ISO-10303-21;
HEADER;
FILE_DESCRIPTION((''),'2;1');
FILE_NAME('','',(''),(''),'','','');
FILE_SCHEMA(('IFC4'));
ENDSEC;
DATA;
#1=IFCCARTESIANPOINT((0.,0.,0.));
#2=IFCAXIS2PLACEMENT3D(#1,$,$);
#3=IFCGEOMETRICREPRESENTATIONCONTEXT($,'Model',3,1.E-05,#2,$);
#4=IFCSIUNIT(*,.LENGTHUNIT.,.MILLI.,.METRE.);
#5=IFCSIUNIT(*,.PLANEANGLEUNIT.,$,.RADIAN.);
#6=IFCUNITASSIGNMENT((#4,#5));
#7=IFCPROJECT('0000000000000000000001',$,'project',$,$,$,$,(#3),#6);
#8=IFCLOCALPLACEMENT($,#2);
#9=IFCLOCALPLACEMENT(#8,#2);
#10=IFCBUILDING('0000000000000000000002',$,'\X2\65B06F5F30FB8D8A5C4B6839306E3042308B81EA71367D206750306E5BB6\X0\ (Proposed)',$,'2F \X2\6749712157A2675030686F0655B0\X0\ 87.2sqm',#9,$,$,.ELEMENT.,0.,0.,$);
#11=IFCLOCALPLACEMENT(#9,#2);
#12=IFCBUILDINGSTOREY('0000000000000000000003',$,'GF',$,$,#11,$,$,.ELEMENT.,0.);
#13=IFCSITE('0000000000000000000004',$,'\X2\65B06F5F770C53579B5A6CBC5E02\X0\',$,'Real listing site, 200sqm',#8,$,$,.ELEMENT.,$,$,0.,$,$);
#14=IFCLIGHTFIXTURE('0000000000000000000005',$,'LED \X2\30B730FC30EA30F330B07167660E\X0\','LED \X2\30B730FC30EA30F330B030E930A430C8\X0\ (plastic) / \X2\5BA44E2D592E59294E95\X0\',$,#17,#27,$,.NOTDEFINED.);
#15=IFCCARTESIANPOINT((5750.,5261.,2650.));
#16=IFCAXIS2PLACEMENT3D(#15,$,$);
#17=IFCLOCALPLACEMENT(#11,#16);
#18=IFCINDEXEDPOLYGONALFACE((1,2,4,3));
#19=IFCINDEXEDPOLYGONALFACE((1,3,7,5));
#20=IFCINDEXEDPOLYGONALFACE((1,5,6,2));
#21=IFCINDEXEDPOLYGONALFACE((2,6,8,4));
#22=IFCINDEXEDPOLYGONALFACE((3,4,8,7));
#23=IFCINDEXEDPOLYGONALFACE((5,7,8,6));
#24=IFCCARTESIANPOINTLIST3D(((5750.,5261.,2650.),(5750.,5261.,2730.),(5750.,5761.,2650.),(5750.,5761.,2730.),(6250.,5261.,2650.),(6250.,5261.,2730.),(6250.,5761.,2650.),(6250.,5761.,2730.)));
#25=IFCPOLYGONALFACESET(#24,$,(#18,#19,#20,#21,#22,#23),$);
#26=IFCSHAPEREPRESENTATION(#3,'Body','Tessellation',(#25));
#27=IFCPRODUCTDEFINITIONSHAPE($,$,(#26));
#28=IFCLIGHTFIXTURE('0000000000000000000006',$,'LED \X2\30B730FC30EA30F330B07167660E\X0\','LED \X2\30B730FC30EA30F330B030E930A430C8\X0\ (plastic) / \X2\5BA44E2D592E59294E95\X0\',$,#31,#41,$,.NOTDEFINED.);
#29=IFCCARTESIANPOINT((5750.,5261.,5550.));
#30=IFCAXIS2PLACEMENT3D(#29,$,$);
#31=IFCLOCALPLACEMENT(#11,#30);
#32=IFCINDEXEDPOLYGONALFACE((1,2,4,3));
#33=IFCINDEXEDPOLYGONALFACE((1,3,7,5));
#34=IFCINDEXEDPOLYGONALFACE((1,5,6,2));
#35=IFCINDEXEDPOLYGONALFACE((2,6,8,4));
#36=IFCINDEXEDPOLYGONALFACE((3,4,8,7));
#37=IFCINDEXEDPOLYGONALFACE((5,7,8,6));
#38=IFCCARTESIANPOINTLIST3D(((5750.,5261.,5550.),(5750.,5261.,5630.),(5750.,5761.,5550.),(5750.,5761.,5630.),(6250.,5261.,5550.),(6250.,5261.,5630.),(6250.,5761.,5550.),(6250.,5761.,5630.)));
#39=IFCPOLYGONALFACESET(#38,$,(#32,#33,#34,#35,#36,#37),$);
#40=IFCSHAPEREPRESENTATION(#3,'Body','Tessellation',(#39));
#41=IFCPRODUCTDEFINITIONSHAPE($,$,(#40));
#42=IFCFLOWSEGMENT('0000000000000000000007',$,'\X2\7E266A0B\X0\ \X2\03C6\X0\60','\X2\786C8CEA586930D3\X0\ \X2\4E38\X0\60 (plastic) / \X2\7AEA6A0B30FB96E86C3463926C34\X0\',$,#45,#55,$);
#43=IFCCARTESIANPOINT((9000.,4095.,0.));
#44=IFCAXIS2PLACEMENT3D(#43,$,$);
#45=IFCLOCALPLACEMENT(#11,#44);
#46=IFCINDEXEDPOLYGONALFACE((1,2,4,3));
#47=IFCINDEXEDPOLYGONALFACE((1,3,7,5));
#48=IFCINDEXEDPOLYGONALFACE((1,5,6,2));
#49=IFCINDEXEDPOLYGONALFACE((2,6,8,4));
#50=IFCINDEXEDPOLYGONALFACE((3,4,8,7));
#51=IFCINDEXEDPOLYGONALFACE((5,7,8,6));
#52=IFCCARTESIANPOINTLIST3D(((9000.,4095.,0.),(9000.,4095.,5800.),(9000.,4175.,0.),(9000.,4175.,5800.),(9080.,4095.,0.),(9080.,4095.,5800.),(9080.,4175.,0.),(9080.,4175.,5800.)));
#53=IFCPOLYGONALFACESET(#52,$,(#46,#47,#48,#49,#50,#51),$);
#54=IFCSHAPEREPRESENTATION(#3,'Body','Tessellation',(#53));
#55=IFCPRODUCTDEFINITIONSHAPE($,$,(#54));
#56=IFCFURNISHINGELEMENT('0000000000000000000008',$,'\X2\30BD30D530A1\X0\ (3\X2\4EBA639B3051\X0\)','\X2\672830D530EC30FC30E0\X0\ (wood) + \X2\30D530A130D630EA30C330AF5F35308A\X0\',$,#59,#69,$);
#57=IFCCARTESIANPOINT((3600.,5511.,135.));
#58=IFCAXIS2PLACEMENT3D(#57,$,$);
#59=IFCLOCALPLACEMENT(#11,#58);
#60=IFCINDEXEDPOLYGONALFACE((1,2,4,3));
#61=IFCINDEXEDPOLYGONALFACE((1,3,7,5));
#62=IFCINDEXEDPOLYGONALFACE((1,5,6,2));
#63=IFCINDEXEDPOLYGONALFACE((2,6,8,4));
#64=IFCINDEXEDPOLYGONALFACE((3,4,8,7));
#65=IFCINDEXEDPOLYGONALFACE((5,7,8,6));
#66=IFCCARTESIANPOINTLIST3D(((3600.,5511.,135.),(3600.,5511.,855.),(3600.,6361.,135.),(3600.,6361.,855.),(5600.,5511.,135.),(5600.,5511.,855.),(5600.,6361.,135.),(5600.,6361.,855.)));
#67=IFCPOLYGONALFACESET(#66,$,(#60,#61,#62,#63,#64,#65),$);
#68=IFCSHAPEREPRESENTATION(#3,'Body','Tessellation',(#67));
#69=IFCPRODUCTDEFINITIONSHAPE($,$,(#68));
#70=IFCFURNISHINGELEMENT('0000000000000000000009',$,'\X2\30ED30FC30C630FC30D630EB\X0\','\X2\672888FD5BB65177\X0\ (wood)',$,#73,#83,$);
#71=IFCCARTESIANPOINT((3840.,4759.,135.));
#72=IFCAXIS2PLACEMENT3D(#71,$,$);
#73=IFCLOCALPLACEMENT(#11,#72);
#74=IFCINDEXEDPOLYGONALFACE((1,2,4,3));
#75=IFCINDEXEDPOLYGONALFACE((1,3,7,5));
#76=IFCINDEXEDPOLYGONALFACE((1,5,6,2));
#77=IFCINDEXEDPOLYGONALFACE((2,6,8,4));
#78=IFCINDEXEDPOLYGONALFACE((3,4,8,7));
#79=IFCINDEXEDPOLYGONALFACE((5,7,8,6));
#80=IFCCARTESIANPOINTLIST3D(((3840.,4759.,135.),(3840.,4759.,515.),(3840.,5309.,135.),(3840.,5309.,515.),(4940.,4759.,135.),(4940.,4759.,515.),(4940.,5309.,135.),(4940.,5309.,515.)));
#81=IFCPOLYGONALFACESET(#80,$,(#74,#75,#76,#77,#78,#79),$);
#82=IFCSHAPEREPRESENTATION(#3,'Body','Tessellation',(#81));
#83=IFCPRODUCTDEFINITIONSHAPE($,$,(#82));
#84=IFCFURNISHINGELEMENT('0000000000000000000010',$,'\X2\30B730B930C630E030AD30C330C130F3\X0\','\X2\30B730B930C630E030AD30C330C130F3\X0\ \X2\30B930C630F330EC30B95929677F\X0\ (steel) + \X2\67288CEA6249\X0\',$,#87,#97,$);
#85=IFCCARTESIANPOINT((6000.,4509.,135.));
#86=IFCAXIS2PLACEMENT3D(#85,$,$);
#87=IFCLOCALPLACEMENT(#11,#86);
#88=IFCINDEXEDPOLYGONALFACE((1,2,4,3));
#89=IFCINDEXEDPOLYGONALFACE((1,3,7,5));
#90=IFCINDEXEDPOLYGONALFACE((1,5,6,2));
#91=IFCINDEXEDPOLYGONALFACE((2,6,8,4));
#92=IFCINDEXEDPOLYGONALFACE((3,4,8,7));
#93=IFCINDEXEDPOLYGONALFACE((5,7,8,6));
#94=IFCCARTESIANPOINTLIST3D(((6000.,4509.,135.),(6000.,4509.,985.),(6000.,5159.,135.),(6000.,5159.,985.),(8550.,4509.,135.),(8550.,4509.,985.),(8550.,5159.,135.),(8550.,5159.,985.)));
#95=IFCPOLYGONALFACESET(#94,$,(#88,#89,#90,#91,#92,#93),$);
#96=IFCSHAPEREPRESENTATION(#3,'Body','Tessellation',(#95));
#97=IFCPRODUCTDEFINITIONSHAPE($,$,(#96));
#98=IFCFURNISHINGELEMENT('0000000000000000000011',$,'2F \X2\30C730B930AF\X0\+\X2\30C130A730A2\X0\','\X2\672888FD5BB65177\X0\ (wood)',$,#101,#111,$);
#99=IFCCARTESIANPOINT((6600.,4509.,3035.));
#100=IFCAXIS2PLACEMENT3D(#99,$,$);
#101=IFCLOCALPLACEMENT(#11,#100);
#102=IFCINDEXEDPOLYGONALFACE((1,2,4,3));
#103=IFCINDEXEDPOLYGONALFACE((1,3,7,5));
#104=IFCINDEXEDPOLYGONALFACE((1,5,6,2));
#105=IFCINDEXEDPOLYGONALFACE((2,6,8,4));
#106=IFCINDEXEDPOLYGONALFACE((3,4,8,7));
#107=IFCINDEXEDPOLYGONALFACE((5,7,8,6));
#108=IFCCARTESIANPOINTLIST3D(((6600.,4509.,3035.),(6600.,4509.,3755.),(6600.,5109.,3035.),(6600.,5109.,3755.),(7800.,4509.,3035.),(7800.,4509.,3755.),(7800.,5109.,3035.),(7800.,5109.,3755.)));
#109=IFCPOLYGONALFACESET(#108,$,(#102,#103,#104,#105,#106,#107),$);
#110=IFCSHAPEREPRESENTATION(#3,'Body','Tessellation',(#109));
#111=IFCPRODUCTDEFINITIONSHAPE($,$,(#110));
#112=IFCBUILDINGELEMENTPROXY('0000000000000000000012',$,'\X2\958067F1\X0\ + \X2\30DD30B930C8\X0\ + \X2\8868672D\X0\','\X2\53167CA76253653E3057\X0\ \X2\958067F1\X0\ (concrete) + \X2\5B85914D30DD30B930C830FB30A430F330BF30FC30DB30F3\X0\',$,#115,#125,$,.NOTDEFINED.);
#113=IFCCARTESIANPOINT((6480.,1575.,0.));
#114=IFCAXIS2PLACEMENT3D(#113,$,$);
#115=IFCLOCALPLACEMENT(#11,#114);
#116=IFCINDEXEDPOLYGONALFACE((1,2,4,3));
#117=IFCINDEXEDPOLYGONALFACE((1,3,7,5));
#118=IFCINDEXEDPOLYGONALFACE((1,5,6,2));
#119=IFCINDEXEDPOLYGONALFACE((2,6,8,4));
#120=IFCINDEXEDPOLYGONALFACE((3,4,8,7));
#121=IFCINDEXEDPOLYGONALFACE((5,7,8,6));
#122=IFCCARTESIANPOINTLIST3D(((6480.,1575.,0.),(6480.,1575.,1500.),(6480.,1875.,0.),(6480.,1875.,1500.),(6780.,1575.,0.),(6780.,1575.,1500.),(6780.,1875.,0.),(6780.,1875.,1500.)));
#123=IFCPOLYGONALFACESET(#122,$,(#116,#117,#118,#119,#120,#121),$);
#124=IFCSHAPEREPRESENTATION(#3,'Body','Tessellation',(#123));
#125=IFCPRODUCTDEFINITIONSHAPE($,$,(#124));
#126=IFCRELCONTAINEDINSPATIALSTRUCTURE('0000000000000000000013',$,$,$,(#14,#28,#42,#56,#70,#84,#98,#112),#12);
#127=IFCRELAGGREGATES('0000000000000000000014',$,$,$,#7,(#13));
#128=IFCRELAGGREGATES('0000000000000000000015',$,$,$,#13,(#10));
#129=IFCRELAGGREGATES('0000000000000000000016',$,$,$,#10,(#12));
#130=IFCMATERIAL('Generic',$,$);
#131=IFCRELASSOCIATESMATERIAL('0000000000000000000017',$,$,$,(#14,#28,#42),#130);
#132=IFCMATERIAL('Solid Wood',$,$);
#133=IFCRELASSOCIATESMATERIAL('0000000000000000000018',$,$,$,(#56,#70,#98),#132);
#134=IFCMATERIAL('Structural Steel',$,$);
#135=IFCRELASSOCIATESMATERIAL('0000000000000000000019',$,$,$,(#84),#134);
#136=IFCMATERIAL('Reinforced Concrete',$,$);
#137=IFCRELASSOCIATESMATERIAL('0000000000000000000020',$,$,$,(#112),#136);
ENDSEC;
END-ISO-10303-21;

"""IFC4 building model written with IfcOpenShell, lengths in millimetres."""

from ifc_helpers import new_model, si_unit, frame, frame_2d, origin, place, context, project, spatial, rectangle, extrude, material, element, save


model = new_model("IFC4")

# Units and contexts
model_context = context("Model", 3, precision=1e-05, world=origin())
ifc_project = project(units=[si_unit("LENGTHUNIT", "METRE", prefix="MILLI"), si_unit("PLANEANGLEUNIT", "RADIAN")], contexts=[model_context])

# Site, building, storey
site_placement = place(None, origin())
site = spatial("IfcSite", under=ifc_project, at=site_placement, Name="新潟県南魚沼市", ObjectType="Real listing site, 200sqm", CompositionType="ELEMENT", RefElevation=0.0)
building_placement = place(site_placement, origin())
building = spatial("IfcBuilding", under=site, at=building_placement, Name="新潟・越屋根のある自然素材の家 (Proposed)", ObjectType="2F 杉無垢材と漆喰 87.2sqm", CompositionType="ELEMENT", ElevationOfRefHeight=0.0, ElevationOfTerrain=0.0)
storey_placement = place(building_placement, origin())
storey = spatial("IfcBuildingStorey", under=building, at=storey_placement, Name="GF", CompositionType="ELEMENT", Elevation=0.0)

# Shared definitions
ifc_material_1 = material(Name="Solid Wood")

# Shared definitions
ifc_material_2 = material(Name="Reinforced Concrete")

# Shared definitions
ifc_material_3 = material(Name="Structural Steel")

# Shared definitions
ifc_material_4 = material(Name="Generic")

# Light fixtures
light_fixture_1_placement = place(storey_placement, frame((5750.0, 5261.0, 2650.0)))
element("IfcLightFixture", 1, at=light_fixture_1_placement, inside=storey, material=ifc_material_4, Name="LED シーリング照明", Description="LED シーリングライト (plastic) / 室中央天井", PredefinedType="NOTDEFINED", context=model_context, shape_type="SweptSolid", body=[
    extrude(rectangle(XDim=500.0, YDim=500.0, at=frame_2d((250.0, 250.0))), frame((5750.0, 5261.0, 2650.0)), (0.0, 0.0, 1.0), 80.0),
])
light_fixture_2_placement = place(storey_placement, frame((5750.0, 5261.0, 5550.0)))
element("IfcLightFixture", 2, at=light_fixture_2_placement, inside=storey, material=ifc_material_4, Name="LED シーリング照明", Description="LED シーリングライト (plastic) / 室中央天井", PredefinedType="NOTDEFINED", context=model_context, shape_type="SweptSolid", body=[
    extrude(rectangle(XDim=500.0, YDim=500.0, at=frame_2d((250.0, 250.0))), frame((5750.0, 5261.0, 5550.0)), (0.0, 0.0, 1.0), 80.0),
])

# Flow segment
flow_segment_placement = place(storey_placement, frame((9000.0, 4095.0, 0.0)))
element("IfcFlowSegment", 3, at=flow_segment_placement, inside=storey, material=ifc_material_4, Name="縦樋 φ60", Description="硬質塩ビ 丸60 (plastic) / 竪樋・雨水排水", context=model_context, shape_type="SweptSolid", body=[
    extrude(rectangle(XDim=80.0, YDim=80.0, at=frame_2d((40.0, 40.0))), frame((9000.0, 4095.0, 0.0)), (0.0, 0.0, 1.0), 5800.0),
])

# Furnishing elements
furnishing_1_placement = place(storey_placement, frame((3600.0, 5511.0, 135.0)))
element("IfcFurnishingElement", 4, at=furnishing_1_placement, inside=storey, material=ifc_material_1, Name="ソファ (3人掛け)", Description="木フレーム (wood) + ファブリック張り", context=model_context, shape_type="SweptSolid", body=[
    extrude(rectangle(XDim=2000.0, YDim=850.0, at=frame_2d((1000.0, 425.0))), frame((3600.0, 5511.0, 135.0)), (0.0, 0.0, 1.0), 720.0),
])
furnishing_2_placement = place(storey_placement, frame((3840.0, 4759.0, 135.0)))
element("IfcFurnishingElement", 5, at=furnishing_2_placement, inside=storey, material=ifc_material_1, Name="ローテーブル", Description="木製家具 (wood)", context=model_context, shape_type="SweptSolid", body=[
    extrude(rectangle(XDim=1100.0, YDim=550.0, at=frame_2d((550.0, 275.0))), frame((3840.0, 4759.0, 135.0)), (0.0, 0.0, 1.0), 380.0),
])
furnishing_3_placement = place(storey_placement, frame((6000.0, 4509.0, 135.0)))
element("IfcFurnishingElement", 6, at=furnishing_3_placement, inside=storey, material=ifc_material_3, Name="システムキッチン", Description="システムキッチン ステンレス天板 (steel) + 木質扉", context=model_context, shape_type="SweptSolid", body=[
    extrude(rectangle(XDim=2550.0, YDim=650.0, at=frame_2d((1275.0, 325.0))), frame((6000.0, 4509.0, 135.0)), (0.0, 0.0, 1.0), 850.0),
])
furnishing_4_placement = place(storey_placement, frame((6600.0, 4509.0, 3035.0)))
element("IfcFurnishingElement", 7, at=furnishing_4_placement, inside=storey, material=ifc_material_1, Name="2F デスク+チェア", Description="木製家具 (wood)", context=model_context, shape_type="SweptSolid", body=[
    extrude(rectangle(XDim=1200.0, YDim=600.0, at=frame_2d((600.0, 300.0))), frame((6600.0, 4509.0, 3035.0)), (0.0, 0.0, 1.0), 720.0),
])

# Building element proxy
proxy_placement = place(storey_placement, frame((6480.0, 1575.0, 0.0)))
element("IfcBuildingElementProxy", 8, at=proxy_placement, inside=storey, material=ifc_material_2, Name="門柱 + ポスト + 表札", Description="化粧打放し 門柱 (concrete) + 宅配ポスト・インターホン", PredefinedType="NOTDEFINED", context=model_context, shape_type="SweptSolid", body=[
    extrude(rectangle(XDim=300.0, YDim=300.0, at=frame_2d((150.0, 150.0))), frame((6480.0, 1575.0, 0.0)), (0.0, 0.0, 1.0), 1500.0),
])

save(model, "model.ifc")
